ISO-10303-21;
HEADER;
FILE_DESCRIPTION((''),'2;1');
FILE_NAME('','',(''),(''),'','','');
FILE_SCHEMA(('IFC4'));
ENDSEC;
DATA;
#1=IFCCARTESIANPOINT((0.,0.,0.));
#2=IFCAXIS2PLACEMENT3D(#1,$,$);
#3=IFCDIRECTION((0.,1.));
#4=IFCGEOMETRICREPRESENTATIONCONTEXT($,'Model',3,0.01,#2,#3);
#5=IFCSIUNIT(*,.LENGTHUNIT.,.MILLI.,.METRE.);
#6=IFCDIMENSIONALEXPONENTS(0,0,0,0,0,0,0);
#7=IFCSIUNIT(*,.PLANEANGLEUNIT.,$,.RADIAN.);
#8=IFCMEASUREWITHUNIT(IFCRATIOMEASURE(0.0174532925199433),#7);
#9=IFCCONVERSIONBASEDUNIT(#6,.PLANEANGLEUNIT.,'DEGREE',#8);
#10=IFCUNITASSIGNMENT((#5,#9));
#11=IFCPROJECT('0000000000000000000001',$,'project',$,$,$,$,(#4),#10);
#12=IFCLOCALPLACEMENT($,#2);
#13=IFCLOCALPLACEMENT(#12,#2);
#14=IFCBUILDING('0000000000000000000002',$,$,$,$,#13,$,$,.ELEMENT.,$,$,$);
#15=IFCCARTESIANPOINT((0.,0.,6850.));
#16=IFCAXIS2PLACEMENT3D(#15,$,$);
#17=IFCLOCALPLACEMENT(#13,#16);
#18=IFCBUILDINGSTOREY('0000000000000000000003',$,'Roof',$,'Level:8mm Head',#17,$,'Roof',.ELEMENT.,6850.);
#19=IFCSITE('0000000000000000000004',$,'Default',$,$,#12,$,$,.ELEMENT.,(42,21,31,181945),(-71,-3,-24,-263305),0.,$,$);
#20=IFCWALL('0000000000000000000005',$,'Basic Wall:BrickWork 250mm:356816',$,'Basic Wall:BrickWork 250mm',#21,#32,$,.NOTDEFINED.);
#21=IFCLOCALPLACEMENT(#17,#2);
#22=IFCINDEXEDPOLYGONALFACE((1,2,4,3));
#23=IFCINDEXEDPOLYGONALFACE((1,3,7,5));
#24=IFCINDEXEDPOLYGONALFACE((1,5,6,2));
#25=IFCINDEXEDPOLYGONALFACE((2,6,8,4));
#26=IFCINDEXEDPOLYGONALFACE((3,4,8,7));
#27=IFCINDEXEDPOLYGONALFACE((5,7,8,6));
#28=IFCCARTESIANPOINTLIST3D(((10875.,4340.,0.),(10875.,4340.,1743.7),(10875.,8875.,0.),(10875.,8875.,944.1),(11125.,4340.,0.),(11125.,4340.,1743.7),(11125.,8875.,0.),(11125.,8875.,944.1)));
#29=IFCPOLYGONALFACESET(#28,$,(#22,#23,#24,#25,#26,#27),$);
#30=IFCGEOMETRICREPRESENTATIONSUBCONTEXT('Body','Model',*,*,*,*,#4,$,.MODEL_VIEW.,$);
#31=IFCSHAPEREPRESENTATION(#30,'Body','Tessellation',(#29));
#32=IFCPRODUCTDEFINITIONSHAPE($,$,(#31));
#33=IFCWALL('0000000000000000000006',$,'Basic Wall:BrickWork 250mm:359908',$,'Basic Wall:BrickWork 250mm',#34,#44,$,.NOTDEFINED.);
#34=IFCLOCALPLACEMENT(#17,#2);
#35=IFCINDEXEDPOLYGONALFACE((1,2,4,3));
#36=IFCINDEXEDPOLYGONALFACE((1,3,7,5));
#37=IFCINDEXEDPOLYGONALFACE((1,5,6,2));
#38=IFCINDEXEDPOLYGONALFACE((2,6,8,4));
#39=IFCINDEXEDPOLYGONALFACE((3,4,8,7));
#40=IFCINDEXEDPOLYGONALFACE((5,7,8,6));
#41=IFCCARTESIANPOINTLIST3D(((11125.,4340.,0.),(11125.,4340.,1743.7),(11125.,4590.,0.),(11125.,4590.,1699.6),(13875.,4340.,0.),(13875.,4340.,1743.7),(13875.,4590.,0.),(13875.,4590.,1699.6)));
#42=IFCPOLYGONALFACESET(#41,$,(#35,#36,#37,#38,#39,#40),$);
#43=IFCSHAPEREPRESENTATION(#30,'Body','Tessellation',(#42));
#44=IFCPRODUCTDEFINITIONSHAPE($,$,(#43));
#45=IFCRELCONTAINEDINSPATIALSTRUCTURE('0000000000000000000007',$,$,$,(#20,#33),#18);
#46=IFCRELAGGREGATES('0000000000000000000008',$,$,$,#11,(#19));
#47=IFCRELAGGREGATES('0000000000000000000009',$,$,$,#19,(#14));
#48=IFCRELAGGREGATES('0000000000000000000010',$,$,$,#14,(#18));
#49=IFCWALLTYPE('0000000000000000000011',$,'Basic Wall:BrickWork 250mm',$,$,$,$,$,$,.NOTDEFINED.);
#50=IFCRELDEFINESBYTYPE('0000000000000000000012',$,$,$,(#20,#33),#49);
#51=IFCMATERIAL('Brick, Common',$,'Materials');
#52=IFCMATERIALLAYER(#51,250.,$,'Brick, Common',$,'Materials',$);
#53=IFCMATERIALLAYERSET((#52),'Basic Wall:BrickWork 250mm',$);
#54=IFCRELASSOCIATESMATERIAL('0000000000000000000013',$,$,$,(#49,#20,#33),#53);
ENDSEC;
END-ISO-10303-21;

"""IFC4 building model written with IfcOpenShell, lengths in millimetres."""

from ifc_helpers import new_model, entity, si_unit, converted_unit, direction, frame, frame_2d, origin, place, context, subcontext, project, spatial, polyline, rectangle, extrude, clip, bounded_halfspace, material, layer, layer_set, layer_usage, type_object, element, save


model = new_model("IFC4")

# Units and contexts
model_context = context("Model", 3, precision=0.01, world=origin(), true_north=direction((0.0, 1.0)))
body_context = subcontext(model_context, "Body", "Model", "MODEL_VIEW")
ifc_project = project(units=[si_unit("LENGTHUNIT", "METRE", prefix="MILLI"), converted_unit("PLANEANGLEUNIT", "DEGREE", entity("IfcRatioMeasure", 0.0174532925199433), si_unit("PLANEANGLEUNIT", "RADIAN"), dimensions=[0, 0, 0, 0, 0, 0, 0])], contexts=[model_context])

# Site, building, storey
site_placement = place(None, origin())
site = spatial("IfcSite", under=ifc_project, at=site_placement, Name="Default", CompositionType="ELEMENT", RefLatitude=(42, 21, 31, 181945), RefLongitude=(-71, -3, -24, -263305), RefElevation=0.0)
building_placement = place(site_placement, origin())
building = spatial("IfcBuilding", under=site, at=building_placement, CompositionType="ELEMENT")
storey_placement = place(building_placement, frame((0.0, 0.0, 6850.0)))
storey = spatial("IfcBuildingStorey", under=building, at=storey_placement, Name="Roof", ObjectType="Level:8mm Head", LongName="Roof", CompositionType="ELEMENT", Elevation=6850.0)

# Walls
ifc_material = material(Name="Brick, Common", Category="Materials")
ifc_layer = layer(ifc_material, 250.0, Name="Brick, Common", Category="Materials")
ifc_layer_set = layer_set([ifc_layer], Name="Basic Wall:BrickWork 250mm")
ifc_layer_usage_1 = layer_usage(ifc_layer_set, "AXIS2", "POSITIVE", -125.0)
wall_type = type_object("IfcWallType", Name="Basic Wall:BrickWork 250mm", PredefinedType="NOTDEFINED", material=ifc_layer_set)
wall_1_placement = place(storey_placement, frame((11000.0, 8875.0, 0.0), z_axis=(0.0, 0.0, 1.0), x_axis=(0.0, -1.0, 0.0)))
element("IfcWall", 1, at=wall_1_placement, inside=storey, type_object=wall_type, material=ifc_layer_usage_1, Name="Basic Wall:BrickWork 250mm:356816", ObjectType="Basic Wall:BrickWork 250mm", PredefinedType="NOTDEFINED", context=body_context, shape_type="Clipping", body=[
    clip(extrude(rectangle(XDim=4535.0, YDim=250.0, at=frame_2d((2267.5, 0.0), x_axis=(-1.0, 0.0))), origin(), (0.0, 0.0, 1.0), 1743.7), bounded_halfspace(frame((0.0, -125.0, 944.1), z_axis=(-0.173648, 0.0, 0.984808), x_axis=(0.0, -1.0, 0.0)), False, frame((0.0, -125.0, 944.1)), polyline([(0.0, 0.0), (4535.0, 0.0), (4535.0, 250.0), (4285.0, 250.0), (0.0, 250.0), (0.0, 0.0)]))),
])
ifc_layer_usage_2 = layer_usage(ifc_layer_set, "AXIS2", "POSITIVE", -125.0)
wall_2_placement = place(storey_placement, frame((11125.0, 4465.0, 0.0)))
element("IfcWall", 2, at=wall_2_placement, inside=storey, type_object=wall_type, material=ifc_layer_usage_2, Name="Basic Wall:BrickWork 250mm:359908", ObjectType="Basic Wall:BrickWork 250mm", PredefinedType="NOTDEFINED", context=body_context, shape_type="Clipping", body=[
    clip(extrude(rectangle(XDim=2750.0, YDim=250.0, at=frame_2d((1375.0, 0.0), x_axis=(-1.0, 0.0))), origin(), (0.0, 0.0, 1.0), 1743.7), bounded_halfspace(frame((0.0, -125.0, 1743.7), z_axis=(0.0, 0.173648, 0.984808), x_axis=(-1.0, 0.0, 0.0)), False, frame((0.0, -125.0, 1743.7)), polyline([(0.0, 0.0), (2750.0, 0.0), (2750.0, 250.0), (0.0, 250.0), (0.0, 0.0)]))),
])

save(model, "model.ifc")
